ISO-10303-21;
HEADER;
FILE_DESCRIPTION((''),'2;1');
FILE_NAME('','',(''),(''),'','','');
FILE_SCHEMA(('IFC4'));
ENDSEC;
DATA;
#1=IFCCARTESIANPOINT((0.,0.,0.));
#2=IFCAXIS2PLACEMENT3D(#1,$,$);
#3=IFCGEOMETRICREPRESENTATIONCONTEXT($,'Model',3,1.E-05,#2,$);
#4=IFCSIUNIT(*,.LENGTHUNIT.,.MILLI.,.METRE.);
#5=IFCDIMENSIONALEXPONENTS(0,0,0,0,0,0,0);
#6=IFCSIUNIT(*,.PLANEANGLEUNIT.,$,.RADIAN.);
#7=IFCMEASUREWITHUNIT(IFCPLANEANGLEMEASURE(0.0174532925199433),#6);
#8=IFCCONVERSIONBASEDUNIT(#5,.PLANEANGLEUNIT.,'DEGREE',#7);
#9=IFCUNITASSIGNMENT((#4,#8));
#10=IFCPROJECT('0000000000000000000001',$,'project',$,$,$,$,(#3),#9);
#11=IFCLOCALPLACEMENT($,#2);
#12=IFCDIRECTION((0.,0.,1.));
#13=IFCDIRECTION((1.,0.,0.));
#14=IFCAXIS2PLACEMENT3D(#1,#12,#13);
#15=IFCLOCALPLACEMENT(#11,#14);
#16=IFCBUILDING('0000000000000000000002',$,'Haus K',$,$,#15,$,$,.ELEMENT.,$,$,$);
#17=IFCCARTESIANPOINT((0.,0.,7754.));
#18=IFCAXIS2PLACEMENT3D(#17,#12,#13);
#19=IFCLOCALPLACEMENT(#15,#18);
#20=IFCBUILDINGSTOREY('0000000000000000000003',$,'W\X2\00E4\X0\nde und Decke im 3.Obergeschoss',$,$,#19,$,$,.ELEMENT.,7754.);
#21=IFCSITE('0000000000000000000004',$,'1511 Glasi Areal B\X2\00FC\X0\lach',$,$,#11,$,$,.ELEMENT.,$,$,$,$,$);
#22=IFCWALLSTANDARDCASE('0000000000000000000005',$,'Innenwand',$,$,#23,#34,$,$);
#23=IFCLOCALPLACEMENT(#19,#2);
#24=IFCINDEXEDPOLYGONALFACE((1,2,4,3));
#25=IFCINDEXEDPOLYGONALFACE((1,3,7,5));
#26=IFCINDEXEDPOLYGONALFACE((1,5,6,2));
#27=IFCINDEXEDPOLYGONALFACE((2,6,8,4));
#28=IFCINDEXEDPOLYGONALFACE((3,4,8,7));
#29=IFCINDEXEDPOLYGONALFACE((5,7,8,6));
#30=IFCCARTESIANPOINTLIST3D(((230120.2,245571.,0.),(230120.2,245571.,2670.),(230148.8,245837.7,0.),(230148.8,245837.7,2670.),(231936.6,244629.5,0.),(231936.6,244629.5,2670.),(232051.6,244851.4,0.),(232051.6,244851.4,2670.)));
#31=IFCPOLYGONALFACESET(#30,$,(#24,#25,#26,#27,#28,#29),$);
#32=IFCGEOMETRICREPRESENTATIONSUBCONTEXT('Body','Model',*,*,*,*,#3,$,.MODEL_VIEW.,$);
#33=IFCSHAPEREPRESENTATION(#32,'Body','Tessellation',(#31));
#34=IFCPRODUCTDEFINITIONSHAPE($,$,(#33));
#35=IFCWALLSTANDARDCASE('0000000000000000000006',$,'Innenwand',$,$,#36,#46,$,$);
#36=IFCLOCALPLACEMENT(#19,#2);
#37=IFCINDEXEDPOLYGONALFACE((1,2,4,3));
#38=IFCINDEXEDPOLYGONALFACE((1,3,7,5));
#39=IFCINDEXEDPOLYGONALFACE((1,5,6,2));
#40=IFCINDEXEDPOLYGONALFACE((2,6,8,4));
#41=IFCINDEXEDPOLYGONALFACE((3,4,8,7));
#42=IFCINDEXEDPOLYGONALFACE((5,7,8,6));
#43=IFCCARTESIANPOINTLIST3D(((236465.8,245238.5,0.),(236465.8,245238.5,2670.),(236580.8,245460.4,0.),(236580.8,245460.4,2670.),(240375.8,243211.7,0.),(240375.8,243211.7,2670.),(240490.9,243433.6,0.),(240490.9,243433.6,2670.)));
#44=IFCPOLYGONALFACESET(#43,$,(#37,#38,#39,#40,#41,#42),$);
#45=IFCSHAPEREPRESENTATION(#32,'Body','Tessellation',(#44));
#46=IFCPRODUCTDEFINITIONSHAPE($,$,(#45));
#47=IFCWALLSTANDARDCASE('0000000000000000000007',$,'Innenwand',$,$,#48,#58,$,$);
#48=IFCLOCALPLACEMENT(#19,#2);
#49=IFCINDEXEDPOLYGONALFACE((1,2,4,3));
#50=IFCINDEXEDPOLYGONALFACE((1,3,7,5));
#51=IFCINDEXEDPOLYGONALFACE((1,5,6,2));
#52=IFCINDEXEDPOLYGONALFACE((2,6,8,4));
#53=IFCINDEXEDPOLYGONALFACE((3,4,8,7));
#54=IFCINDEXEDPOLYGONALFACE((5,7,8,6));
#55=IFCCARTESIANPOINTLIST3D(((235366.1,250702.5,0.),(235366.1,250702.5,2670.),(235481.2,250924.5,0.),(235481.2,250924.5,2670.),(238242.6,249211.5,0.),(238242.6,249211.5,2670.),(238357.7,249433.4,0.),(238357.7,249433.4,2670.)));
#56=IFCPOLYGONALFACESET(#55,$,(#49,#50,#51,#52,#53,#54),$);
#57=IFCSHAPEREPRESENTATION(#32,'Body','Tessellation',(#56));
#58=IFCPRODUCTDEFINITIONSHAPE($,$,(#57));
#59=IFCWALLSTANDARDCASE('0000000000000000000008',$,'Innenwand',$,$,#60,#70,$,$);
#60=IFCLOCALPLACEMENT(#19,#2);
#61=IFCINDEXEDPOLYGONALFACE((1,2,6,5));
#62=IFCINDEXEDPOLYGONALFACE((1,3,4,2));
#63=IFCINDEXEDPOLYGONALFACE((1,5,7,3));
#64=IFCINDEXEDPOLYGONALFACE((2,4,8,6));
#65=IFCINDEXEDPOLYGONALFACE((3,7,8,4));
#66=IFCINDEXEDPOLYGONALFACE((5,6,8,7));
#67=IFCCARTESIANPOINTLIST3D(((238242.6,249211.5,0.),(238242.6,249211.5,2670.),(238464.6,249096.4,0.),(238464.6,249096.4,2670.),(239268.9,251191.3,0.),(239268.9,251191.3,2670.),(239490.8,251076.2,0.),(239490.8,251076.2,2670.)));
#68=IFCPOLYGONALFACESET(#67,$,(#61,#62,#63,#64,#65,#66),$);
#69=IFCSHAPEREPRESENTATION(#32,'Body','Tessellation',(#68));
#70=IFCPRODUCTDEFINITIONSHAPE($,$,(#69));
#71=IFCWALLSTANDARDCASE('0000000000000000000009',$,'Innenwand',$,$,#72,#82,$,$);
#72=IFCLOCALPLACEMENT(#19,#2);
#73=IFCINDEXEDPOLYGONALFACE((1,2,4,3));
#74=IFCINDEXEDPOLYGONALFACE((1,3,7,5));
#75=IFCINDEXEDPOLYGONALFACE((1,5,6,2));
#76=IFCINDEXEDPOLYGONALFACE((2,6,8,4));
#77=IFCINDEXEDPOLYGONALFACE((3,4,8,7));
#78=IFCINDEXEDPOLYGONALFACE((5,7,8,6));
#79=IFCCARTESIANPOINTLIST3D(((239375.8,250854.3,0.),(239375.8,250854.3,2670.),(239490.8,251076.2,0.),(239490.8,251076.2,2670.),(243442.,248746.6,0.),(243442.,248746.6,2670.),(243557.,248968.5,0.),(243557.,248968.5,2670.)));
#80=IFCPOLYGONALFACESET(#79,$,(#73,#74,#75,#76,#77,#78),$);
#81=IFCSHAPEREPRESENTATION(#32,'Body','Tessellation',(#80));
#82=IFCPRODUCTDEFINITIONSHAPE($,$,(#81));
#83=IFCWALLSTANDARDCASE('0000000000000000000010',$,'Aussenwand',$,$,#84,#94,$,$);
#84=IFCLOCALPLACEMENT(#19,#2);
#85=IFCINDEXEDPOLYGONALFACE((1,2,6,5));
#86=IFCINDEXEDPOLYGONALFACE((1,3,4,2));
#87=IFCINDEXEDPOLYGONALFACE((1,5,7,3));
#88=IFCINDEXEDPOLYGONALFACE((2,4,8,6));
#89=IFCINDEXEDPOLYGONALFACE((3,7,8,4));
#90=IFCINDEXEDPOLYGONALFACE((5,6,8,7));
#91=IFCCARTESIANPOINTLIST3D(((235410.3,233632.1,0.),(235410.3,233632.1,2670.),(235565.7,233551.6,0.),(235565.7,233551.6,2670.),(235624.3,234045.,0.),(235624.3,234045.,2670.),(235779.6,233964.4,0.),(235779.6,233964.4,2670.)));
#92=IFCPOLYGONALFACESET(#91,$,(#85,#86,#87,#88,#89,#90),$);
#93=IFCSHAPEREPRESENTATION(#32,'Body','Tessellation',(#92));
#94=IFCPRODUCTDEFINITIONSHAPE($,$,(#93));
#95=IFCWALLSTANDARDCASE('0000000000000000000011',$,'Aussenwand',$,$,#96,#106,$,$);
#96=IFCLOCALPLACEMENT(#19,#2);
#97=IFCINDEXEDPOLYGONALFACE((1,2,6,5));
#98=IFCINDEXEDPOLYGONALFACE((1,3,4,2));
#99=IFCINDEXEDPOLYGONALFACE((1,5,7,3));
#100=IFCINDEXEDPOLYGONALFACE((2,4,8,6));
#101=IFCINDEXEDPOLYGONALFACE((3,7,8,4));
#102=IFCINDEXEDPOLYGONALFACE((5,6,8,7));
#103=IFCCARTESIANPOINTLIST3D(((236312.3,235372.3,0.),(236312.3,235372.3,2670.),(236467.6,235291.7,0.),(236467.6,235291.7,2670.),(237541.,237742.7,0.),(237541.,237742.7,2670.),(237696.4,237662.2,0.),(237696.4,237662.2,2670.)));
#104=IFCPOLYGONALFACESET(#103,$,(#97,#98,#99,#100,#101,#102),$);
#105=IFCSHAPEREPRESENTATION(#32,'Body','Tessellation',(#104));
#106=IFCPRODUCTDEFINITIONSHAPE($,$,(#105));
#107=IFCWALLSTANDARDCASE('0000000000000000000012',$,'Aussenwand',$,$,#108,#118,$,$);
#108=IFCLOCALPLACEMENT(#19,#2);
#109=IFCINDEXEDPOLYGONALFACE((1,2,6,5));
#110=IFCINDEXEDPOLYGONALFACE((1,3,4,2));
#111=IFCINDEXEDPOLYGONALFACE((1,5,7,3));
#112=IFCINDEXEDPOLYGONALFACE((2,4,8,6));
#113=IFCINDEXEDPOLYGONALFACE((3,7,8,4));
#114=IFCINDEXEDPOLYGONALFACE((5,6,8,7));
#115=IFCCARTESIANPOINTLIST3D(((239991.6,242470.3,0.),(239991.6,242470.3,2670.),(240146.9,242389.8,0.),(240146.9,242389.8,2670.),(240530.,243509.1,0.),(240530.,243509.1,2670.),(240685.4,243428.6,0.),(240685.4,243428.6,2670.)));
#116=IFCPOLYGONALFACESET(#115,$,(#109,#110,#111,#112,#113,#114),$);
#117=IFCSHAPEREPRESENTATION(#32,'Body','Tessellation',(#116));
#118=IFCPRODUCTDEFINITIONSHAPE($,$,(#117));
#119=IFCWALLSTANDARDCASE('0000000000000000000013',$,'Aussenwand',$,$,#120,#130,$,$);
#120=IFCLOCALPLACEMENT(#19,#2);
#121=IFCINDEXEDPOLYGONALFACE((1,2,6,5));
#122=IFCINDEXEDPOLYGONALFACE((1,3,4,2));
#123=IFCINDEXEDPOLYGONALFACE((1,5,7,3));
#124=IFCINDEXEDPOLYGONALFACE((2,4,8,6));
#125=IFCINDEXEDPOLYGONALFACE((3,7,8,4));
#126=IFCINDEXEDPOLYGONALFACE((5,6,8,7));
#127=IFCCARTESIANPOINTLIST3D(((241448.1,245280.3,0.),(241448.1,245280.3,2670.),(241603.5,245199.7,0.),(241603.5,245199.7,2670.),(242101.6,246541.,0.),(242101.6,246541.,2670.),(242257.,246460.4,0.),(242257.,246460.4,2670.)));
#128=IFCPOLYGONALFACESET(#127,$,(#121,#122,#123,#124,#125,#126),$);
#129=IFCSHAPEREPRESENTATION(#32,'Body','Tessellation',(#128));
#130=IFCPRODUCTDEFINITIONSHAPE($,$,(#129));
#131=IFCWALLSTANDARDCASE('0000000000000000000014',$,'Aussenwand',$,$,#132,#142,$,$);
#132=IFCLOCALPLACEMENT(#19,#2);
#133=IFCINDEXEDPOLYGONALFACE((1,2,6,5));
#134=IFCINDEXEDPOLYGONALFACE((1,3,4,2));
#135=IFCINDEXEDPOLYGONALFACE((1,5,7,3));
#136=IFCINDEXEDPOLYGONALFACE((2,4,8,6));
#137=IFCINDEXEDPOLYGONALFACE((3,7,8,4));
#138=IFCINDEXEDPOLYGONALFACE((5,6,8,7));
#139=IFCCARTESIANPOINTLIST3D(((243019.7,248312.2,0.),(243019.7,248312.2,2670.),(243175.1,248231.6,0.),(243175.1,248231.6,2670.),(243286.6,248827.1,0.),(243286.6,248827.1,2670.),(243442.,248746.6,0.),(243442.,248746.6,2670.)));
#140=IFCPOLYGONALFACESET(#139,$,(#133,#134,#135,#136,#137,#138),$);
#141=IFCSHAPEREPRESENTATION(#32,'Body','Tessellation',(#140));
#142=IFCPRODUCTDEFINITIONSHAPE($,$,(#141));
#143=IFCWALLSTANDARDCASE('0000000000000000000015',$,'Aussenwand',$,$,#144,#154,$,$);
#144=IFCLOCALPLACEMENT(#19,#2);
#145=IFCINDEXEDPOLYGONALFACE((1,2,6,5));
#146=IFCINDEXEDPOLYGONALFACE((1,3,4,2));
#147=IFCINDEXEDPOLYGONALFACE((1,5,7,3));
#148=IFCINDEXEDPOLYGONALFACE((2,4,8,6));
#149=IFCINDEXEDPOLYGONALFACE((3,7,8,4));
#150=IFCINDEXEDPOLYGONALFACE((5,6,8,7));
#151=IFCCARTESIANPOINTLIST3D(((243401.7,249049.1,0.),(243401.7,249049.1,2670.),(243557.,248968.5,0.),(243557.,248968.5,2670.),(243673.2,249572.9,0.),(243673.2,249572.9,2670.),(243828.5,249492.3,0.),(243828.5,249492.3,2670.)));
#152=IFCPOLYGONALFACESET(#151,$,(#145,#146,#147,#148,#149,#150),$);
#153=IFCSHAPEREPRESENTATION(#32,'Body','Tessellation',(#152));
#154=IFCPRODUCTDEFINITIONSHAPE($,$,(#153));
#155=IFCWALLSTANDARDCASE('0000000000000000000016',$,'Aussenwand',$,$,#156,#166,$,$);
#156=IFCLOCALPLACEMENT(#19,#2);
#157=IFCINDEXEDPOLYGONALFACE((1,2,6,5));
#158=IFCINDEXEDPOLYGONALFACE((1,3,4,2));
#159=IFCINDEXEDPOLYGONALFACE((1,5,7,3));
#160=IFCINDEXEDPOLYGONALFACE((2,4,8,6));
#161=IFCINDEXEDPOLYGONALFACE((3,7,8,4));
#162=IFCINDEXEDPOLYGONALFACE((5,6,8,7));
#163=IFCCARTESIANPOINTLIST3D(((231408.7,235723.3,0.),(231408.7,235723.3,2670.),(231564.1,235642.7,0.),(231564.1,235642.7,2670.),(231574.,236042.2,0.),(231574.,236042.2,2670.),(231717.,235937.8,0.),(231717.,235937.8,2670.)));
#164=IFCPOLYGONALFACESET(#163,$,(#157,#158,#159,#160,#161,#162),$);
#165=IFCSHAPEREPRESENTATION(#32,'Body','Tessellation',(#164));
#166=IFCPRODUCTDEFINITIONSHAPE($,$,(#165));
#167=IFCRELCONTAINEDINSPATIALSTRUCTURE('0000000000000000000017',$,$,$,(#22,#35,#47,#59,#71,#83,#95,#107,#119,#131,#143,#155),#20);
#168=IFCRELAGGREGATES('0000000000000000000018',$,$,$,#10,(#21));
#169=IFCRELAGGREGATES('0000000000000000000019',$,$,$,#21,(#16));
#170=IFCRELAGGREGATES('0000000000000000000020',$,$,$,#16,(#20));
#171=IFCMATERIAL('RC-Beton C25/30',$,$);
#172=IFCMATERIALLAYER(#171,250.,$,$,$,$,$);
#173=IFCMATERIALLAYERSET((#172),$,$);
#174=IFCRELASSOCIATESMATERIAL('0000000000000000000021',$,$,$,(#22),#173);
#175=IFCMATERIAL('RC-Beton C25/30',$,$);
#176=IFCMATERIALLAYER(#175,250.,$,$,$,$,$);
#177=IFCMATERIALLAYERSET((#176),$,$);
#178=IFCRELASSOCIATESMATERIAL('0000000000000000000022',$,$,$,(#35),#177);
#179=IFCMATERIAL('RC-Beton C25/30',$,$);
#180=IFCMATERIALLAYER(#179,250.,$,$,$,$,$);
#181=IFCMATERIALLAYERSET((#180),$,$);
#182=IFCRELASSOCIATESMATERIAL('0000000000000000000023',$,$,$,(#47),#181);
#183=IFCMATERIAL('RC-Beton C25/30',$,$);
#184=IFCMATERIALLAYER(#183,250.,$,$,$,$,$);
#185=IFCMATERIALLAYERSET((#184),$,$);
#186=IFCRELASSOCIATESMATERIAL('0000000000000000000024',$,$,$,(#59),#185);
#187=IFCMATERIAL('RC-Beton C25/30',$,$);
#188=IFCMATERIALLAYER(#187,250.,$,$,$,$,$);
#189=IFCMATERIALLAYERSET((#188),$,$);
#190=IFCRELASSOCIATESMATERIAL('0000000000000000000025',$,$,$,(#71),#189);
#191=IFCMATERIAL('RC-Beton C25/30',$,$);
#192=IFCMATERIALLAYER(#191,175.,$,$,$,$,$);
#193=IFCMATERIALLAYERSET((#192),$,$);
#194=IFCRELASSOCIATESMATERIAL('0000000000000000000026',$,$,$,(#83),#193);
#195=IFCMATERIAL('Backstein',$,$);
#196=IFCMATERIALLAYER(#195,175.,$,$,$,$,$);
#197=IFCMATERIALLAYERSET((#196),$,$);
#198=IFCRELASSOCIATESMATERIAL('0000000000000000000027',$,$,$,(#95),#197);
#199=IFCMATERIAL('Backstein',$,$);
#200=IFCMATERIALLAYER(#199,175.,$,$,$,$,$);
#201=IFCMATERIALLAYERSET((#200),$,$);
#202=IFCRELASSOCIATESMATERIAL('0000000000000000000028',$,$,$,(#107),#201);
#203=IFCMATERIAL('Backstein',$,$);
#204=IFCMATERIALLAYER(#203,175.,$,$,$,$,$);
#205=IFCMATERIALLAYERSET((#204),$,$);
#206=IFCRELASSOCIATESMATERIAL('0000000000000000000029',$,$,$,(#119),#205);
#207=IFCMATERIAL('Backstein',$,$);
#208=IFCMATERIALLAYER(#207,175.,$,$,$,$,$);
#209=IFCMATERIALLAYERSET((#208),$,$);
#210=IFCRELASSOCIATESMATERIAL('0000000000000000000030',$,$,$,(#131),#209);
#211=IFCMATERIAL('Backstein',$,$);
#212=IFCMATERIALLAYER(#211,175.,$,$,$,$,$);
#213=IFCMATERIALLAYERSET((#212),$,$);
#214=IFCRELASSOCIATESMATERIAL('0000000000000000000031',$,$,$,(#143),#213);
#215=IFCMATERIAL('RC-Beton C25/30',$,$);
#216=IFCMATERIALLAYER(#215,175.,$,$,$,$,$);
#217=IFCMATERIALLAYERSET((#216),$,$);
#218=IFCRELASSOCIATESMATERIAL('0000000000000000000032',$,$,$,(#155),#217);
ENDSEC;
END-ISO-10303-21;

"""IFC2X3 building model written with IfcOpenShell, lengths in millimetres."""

from ifc_helpers import new_model, entity, si_unit, converted_unit, frame, frame_2d, origin, origin_with_axes, place, context, subcontext, project, spatial, polyline, rectangle, outline, extrude, material, layer, layer_set, layer_usage, element, save


model = new_model("IFC2X3")

# Units and contexts
model_context = context("Model", 3, precision=1e-05, world=origin())
body_context = subcontext(model_context, "Body", "Model", "MODEL_VIEW")
ifc_project = project(units=[si_unit("LENGTHUNIT", "METRE", prefix="MILLI"), converted_unit("PLANEANGLEUNIT", "DEGREE", entity("IfcPlaneAngleMeasure", 0.0174532925199433), si_unit("PLANEANGLEUNIT", "RADIAN"), dimensions=[0, 0, 0, 0, 0, 0, 0])], contexts=[model_context])

# Site, building, storey
site_placement = place(None, origin())
site = spatial("IfcSite", under=ifc_project, at=site_placement, Name="1511 Glasi Areal Bülach", CompositionType="ELEMENT")
building_placement = place(site_placement, origin_with_axes())
building = spatial("IfcBuilding", under=site, at=building_placement, Name="Haus K", CompositionType="ELEMENT")
storey_placement = place(building_placement, frame((0.0, 0.0, 7754.0), z_axis=(0.0, 0.0, 1.0), x_axis=(1.0, 0.0, 0.0)))
storey = spatial("IfcBuildingStorey", under=building, at=storey_placement, Name="Wände und Decke im 3.Obergeschoss", CompositionType="ELEMENT", Elevation=7754.0)

# Walls
ifc_material_1 = material(Name="RC-Beton C25/30")
ifc_layer_1 = layer(ifc_material_1, 250.0)
ifc_layer_set_1 = layer_set([ifc_layer_1])
ifc_layer_usage_1 = layer_usage(ifc_layer_set_1, "AXIS2", "POSITIVE", 0.0)
wall_1_placement = place(storey_placement, frame((232051.6, 244851.4, 0.0), z_axis=(0.0, 0.0, 1.0), x_axis=(-0.887815, 0.4602, 0.0)))
element("IfcWallStandardCase", 1, at=wall_1_placement, inside=storey, material=ifc_layer_usage_1, Name="Innenwand", context=body_context, shape_type="SweptSolid", body=[
    extrude(outline(polyline([(0.0, 0.0), (2143.2, 0.0), (2045.9, 250.0), (0.0, 250.0), (0.0, 0.0)])), origin_with_axes(), (0.0, 0.0, 1.0), 2670.0),
])
ifc_material_2 = material(Name="RC-Beton C25/30")
ifc_layer_2 = layer(ifc_material_2, 250.0)
ifc_layer_set_2 = layer_set([ifc_layer_2])
ifc_layer_usage_2 = layer_usage(ifc_layer_set_2, "AXIS2", "POSITIVE", 0.0)
wall_2_placement = place(storey_placement, frame((240490.9, 243433.6, 0.0), z_axis=(0.0, 0.0, 1.0), x_axis=(-0.887815, 0.4602, 0.0)))
element("IfcWallStandardCase", 2, at=wall_2_placement, inside=storey, material=ifc_layer_usage_2, Name="Innenwand", context=body_context, shape_type="SweptSolid", body=[
    extrude(rectangle(XDim=4404.2, YDim=250.0, at=frame_2d((2202.1, 125.0), x_axis=(1.0, 0.0))), origin_with_axes(), (0.0, 0.0, 1.0), 2670.0),
])
ifc_material_3 = material(Name="RC-Beton C25/30")
ifc_layer_3 = layer(ifc_material_3, 250.0)
ifc_layer_set_3 = layer_set([ifc_layer_3])
ifc_layer_usage_3 = layer_usage(ifc_layer_set_3, "AXIS2", "POSITIVE", 0.0)
wall_3_placement = place(storey_placement, frame((238357.7, 249433.4, 0.0), z_axis=(0.0, 0.0, 1.0), x_axis=(-0.887815, 0.4602, 0.0)))
element("IfcWallStandardCase", 3, at=wall_3_placement, inside=storey, material=ifc_layer_usage_3, Name="Innenwand", context=body_context, shape_type="SweptSolid", body=[
    extrude(rectangle(XDim=3240.0, YDim=250.0, at=frame_2d((1620.0, 125.0), x_axis=(1.0, 0.0))), origin_with_axes(), (0.0, 0.0, 1.0), 2670.0),
])
ifc_material_4 = material(Name="RC-Beton C25/30")
ifc_layer_4 = layer(ifc_material_4, 250.0)
ifc_layer_set_4 = layer_set([ifc_layer_4])
ifc_layer_usage_4 = layer_usage(ifc_layer_set_4, "AXIS2", "POSITIVE", 0.0)
wall_4_placement = place(storey_placement, frame((238464.6, 249096.4, 0.0), z_axis=(0.0, 0.0, 1.0), x_axis=(0.4602, 0.887815, 0.0)))
element("IfcWallStandardCase", 4, at=wall_4_placement, inside=storey, material=ifc_layer_usage_4, Name="Innenwand", context=body_context, shape_type="SweptSolid", body=[
    extrude(rectangle(XDim=2230.0, YDim=250.0, at=frame_2d((1115.0, 125.0), x_axis=(1.0, 0.0))), origin_with_axes(), (0.0, 0.0, 1.0), 2670.0),
])
ifc_material_5 = material(Name="RC-Beton C25/30")
ifc_layer_5 = layer(ifc_material_5, 250.0)
ifc_layer_set_5 = layer_set([ifc_layer_5])
ifc_layer_usage_5 = layer_usage(ifc_layer_set_5, "AXIS2", "POSITIVE", 0.0)
wall_5_placement = place(storey_placement, frame((239375.8, 250854.3, 0.0), z_axis=(0.0, 0.0, 1.0), x_axis=(0.887815, -0.4602, 0.0)))
element("IfcWallStandardCase", 5, at=wall_5_placement, inside=storey, material=ifc_layer_usage_5, Name="Innenwand", context=body_context, shape_type="SweptSolid", body=[
    extrude(rectangle(XDim=4580.0, YDim=250.0, at=frame_2d((2290.0, 125.0), x_axis=(1.0, 0.0))), origin_with_axes(), (0.0, 0.0, 1.0), 2670.0),
])
ifc_material_6 = material(Name="RC-Beton C25/30")
ifc_layer_6 = layer(ifc_material_6, 175.0)
ifc_layer_set_6 = layer_set([ifc_layer_6])
ifc_layer_usage_6 = layer_usage(ifc_layer_set_6, "AXIS2", "POSITIVE", 0.0)
wall_6_placement = place(storey_placement, frame((235565.7, 233551.6, 0.0), z_axis=(0.0, 0.0, 1.0), x_axis=(0.4602, 0.887815, 0.0)))
element("IfcWallStandardCase", 6, at=wall_6_placement, inside=storey, material=ifc_layer_usage_6, Name="Aussenwand", context=body_context, shape_type="SweptSolid", body=[
    extrude(rectangle(XDim=465.0, YDim=175.0, at=frame_2d((232.5, 87.5), x_axis=(1.0, 0.0))), origin_with_axes(), (0.0, 0.0, 1.0), 2670.0),
])
ifc_material_7 = material(Name="Backstein")
ifc_layer_7 = layer(ifc_material_7, 175.0)
ifc_layer_set_7 = layer_set([ifc_layer_7])
ifc_layer_usage_7 = layer_usage(ifc_layer_set_7, "AXIS2", "POSITIVE", 0.0)
wall_7_placement = place(storey_placement, frame((236467.6, 235291.7, 0.0), z_axis=(0.0, 0.0, 1.0), x_axis=(0.4602, 0.887815, 0.0)))
element("IfcWallStandardCase", 7, at=wall_7_placement, inside=storey, material=ifc_layer_usage_7, Name="Aussenwand", context=body_context, shape_type="SweptSolid", body=[
    extrude(rectangle(XDim=2670.0, YDim=175.0, at=frame_2d((1335.0, 87.5), x_axis=(1.0, 0.0))), origin_with_axes(), (0.0, 0.0, 1.0), 2670.0),
])
ifc_material_8 = material(Name="Backstein")
ifc_layer_8 = layer(ifc_material_8, 175.0)
ifc_layer_set_8 = layer_set([ifc_layer_8])
ifc_layer_usage_8 = layer_usage(ifc_layer_set_8, "AXIS2", "POSITIVE", 0.0)
wall_8_placement = place(storey_placement, frame((240146.9, 242389.8, 0.0), z_axis=(0.0, 0.0, 1.0), x_axis=(0.4602, 0.887815, 0.0)))
element("IfcWallStandardCase", 8, at=wall_8_placement, inside=storey, material=ifc_layer_usage_8, Name="Aussenwand", context=body_context, shape_type="SweptSolid", body=[
    extrude(rectangle(XDim=1170.0, YDim=175.0, at=frame_2d((585.0, 87.5), x_axis=(1.0, 0.0))), origin_with_axes(), (0.0, 0.0, 1.0), 2670.0),
])
ifc_material_9 = material(Name="Backstein")
ifc_layer_9 = layer(ifc_material_9, 175.0)
ifc_layer_set_9 = layer_set([ifc_layer_9])
ifc_layer_usage_9 = layer_usage(ifc_layer_set_9, "AXIS2", "POSITIVE", 0.0)
wall_9_placement = place(storey_placement, frame((241603.5, 245199.7, 0.0), z_axis=(0.0, 0.0, 1.0), x_axis=(0.4602, 0.887815, 0.0)))
element("IfcWallStandardCase", 9, at=wall_9_placement, inside=storey, material=ifc_layer_usage_9, Name="Aussenwand", context=body_context, shape_type="SweptSolid", body=[
    extrude(rectangle(XDim=1420.0, YDim=175.0, at=frame_2d((710.0, 87.5), x_axis=(1.0, 0.0))), origin_with_axes(), (0.0, 0.0, 1.0), 2670.0),
])
ifc_material_10 = material(Name="Backstein")
ifc_layer_10 = layer(ifc_material_10, 175.0)
ifc_layer_set_10 = layer_set([ifc_layer_10])
ifc_layer_usage_10 = layer_usage(ifc_layer_set_10, "AXIS2", "POSITIVE", 0.0)
wall_10_placement = place(storey_placement, frame((243175.1, 248231.6, 0.0), z_axis=(0.0, 0.0, 1.0), x_axis=(0.4602, 0.887815, 0.0)))
element("IfcWallStandardCase", 10, at=wall_10_placement, inside=storey, material=ifc_layer_usage_10, Name="Aussenwand", context=body_context, shape_type="SweptSolid", body=[
    extrude(rectangle(XDim=580.0, YDim=175.0, at=frame_2d((290.0, 87.5), x_axis=(1.0, 0.0))), origin_with_axes(), (0.0, 0.0, 1.0), 2670.0),
])
ifc_material_11 = material(Name="Backstein")
ifc_layer_11 = layer(ifc_material_11, 175.0)
ifc_layer_set_11 = layer_set([ifc_layer_11])
ifc_layer_usage_11 = layer_usage(ifc_layer_set_11, "AXIS2", "POSITIVE", 0.0)
wall_11_placement = place(storey_placement, frame((243557.0, 248968.5, 0.0), z_axis=(0.0, 0.0, 1.0), x_axis=(0.4602, 0.887815, 0.0)))
element("IfcWallStandardCase", 11, at=wall_11_placement, inside=storey, material=ifc_layer_usage_11, Name="Aussenwand", context=body_context, shape_type="SweptSolid", body=[
    extrude(rectangle(XDim=590.0, YDim=175.0, at=frame_2d((295.0, 87.5), x_axis=(1.0, 0.0))), origin_with_axes(), (0.0, 0.0, 1.0), 2670.0),
])
ifc_material_12 = material(Name="RC-Beton C25/30")
ifc_layer_12 = layer(ifc_material_12, 175.0)
ifc_layer_set_12 = layer_set([ifc_layer_12])
ifc_layer_usage_12 = layer_usage(ifc_layer_set_12, "AXIS2", "POSITIVE", 0.0)
wall_12_placement = place(storey_placement, frame((231574.0, 236042.2, 0.0), z_axis=(0.0, 0.0, 1.0), x_axis=(-0.4602, -0.887815, 0.0)))
element("IfcWallStandardCase", 12, at=wall_12_placement, inside=storey, material=ifc_layer_usage_12, Name="Aussenwand", context=body_context, shape_type="SweptSolid", body=[
    extrude(outline(polyline([(0.0, 0.0), (359.2, 0.0), (359.2, 175.0), (26.9, 175.0), (0.0, 0.0)])), origin_with_axes(), (0.0, 0.0, 1.0), 2670.0),
])

save(model, "model.ifc")
